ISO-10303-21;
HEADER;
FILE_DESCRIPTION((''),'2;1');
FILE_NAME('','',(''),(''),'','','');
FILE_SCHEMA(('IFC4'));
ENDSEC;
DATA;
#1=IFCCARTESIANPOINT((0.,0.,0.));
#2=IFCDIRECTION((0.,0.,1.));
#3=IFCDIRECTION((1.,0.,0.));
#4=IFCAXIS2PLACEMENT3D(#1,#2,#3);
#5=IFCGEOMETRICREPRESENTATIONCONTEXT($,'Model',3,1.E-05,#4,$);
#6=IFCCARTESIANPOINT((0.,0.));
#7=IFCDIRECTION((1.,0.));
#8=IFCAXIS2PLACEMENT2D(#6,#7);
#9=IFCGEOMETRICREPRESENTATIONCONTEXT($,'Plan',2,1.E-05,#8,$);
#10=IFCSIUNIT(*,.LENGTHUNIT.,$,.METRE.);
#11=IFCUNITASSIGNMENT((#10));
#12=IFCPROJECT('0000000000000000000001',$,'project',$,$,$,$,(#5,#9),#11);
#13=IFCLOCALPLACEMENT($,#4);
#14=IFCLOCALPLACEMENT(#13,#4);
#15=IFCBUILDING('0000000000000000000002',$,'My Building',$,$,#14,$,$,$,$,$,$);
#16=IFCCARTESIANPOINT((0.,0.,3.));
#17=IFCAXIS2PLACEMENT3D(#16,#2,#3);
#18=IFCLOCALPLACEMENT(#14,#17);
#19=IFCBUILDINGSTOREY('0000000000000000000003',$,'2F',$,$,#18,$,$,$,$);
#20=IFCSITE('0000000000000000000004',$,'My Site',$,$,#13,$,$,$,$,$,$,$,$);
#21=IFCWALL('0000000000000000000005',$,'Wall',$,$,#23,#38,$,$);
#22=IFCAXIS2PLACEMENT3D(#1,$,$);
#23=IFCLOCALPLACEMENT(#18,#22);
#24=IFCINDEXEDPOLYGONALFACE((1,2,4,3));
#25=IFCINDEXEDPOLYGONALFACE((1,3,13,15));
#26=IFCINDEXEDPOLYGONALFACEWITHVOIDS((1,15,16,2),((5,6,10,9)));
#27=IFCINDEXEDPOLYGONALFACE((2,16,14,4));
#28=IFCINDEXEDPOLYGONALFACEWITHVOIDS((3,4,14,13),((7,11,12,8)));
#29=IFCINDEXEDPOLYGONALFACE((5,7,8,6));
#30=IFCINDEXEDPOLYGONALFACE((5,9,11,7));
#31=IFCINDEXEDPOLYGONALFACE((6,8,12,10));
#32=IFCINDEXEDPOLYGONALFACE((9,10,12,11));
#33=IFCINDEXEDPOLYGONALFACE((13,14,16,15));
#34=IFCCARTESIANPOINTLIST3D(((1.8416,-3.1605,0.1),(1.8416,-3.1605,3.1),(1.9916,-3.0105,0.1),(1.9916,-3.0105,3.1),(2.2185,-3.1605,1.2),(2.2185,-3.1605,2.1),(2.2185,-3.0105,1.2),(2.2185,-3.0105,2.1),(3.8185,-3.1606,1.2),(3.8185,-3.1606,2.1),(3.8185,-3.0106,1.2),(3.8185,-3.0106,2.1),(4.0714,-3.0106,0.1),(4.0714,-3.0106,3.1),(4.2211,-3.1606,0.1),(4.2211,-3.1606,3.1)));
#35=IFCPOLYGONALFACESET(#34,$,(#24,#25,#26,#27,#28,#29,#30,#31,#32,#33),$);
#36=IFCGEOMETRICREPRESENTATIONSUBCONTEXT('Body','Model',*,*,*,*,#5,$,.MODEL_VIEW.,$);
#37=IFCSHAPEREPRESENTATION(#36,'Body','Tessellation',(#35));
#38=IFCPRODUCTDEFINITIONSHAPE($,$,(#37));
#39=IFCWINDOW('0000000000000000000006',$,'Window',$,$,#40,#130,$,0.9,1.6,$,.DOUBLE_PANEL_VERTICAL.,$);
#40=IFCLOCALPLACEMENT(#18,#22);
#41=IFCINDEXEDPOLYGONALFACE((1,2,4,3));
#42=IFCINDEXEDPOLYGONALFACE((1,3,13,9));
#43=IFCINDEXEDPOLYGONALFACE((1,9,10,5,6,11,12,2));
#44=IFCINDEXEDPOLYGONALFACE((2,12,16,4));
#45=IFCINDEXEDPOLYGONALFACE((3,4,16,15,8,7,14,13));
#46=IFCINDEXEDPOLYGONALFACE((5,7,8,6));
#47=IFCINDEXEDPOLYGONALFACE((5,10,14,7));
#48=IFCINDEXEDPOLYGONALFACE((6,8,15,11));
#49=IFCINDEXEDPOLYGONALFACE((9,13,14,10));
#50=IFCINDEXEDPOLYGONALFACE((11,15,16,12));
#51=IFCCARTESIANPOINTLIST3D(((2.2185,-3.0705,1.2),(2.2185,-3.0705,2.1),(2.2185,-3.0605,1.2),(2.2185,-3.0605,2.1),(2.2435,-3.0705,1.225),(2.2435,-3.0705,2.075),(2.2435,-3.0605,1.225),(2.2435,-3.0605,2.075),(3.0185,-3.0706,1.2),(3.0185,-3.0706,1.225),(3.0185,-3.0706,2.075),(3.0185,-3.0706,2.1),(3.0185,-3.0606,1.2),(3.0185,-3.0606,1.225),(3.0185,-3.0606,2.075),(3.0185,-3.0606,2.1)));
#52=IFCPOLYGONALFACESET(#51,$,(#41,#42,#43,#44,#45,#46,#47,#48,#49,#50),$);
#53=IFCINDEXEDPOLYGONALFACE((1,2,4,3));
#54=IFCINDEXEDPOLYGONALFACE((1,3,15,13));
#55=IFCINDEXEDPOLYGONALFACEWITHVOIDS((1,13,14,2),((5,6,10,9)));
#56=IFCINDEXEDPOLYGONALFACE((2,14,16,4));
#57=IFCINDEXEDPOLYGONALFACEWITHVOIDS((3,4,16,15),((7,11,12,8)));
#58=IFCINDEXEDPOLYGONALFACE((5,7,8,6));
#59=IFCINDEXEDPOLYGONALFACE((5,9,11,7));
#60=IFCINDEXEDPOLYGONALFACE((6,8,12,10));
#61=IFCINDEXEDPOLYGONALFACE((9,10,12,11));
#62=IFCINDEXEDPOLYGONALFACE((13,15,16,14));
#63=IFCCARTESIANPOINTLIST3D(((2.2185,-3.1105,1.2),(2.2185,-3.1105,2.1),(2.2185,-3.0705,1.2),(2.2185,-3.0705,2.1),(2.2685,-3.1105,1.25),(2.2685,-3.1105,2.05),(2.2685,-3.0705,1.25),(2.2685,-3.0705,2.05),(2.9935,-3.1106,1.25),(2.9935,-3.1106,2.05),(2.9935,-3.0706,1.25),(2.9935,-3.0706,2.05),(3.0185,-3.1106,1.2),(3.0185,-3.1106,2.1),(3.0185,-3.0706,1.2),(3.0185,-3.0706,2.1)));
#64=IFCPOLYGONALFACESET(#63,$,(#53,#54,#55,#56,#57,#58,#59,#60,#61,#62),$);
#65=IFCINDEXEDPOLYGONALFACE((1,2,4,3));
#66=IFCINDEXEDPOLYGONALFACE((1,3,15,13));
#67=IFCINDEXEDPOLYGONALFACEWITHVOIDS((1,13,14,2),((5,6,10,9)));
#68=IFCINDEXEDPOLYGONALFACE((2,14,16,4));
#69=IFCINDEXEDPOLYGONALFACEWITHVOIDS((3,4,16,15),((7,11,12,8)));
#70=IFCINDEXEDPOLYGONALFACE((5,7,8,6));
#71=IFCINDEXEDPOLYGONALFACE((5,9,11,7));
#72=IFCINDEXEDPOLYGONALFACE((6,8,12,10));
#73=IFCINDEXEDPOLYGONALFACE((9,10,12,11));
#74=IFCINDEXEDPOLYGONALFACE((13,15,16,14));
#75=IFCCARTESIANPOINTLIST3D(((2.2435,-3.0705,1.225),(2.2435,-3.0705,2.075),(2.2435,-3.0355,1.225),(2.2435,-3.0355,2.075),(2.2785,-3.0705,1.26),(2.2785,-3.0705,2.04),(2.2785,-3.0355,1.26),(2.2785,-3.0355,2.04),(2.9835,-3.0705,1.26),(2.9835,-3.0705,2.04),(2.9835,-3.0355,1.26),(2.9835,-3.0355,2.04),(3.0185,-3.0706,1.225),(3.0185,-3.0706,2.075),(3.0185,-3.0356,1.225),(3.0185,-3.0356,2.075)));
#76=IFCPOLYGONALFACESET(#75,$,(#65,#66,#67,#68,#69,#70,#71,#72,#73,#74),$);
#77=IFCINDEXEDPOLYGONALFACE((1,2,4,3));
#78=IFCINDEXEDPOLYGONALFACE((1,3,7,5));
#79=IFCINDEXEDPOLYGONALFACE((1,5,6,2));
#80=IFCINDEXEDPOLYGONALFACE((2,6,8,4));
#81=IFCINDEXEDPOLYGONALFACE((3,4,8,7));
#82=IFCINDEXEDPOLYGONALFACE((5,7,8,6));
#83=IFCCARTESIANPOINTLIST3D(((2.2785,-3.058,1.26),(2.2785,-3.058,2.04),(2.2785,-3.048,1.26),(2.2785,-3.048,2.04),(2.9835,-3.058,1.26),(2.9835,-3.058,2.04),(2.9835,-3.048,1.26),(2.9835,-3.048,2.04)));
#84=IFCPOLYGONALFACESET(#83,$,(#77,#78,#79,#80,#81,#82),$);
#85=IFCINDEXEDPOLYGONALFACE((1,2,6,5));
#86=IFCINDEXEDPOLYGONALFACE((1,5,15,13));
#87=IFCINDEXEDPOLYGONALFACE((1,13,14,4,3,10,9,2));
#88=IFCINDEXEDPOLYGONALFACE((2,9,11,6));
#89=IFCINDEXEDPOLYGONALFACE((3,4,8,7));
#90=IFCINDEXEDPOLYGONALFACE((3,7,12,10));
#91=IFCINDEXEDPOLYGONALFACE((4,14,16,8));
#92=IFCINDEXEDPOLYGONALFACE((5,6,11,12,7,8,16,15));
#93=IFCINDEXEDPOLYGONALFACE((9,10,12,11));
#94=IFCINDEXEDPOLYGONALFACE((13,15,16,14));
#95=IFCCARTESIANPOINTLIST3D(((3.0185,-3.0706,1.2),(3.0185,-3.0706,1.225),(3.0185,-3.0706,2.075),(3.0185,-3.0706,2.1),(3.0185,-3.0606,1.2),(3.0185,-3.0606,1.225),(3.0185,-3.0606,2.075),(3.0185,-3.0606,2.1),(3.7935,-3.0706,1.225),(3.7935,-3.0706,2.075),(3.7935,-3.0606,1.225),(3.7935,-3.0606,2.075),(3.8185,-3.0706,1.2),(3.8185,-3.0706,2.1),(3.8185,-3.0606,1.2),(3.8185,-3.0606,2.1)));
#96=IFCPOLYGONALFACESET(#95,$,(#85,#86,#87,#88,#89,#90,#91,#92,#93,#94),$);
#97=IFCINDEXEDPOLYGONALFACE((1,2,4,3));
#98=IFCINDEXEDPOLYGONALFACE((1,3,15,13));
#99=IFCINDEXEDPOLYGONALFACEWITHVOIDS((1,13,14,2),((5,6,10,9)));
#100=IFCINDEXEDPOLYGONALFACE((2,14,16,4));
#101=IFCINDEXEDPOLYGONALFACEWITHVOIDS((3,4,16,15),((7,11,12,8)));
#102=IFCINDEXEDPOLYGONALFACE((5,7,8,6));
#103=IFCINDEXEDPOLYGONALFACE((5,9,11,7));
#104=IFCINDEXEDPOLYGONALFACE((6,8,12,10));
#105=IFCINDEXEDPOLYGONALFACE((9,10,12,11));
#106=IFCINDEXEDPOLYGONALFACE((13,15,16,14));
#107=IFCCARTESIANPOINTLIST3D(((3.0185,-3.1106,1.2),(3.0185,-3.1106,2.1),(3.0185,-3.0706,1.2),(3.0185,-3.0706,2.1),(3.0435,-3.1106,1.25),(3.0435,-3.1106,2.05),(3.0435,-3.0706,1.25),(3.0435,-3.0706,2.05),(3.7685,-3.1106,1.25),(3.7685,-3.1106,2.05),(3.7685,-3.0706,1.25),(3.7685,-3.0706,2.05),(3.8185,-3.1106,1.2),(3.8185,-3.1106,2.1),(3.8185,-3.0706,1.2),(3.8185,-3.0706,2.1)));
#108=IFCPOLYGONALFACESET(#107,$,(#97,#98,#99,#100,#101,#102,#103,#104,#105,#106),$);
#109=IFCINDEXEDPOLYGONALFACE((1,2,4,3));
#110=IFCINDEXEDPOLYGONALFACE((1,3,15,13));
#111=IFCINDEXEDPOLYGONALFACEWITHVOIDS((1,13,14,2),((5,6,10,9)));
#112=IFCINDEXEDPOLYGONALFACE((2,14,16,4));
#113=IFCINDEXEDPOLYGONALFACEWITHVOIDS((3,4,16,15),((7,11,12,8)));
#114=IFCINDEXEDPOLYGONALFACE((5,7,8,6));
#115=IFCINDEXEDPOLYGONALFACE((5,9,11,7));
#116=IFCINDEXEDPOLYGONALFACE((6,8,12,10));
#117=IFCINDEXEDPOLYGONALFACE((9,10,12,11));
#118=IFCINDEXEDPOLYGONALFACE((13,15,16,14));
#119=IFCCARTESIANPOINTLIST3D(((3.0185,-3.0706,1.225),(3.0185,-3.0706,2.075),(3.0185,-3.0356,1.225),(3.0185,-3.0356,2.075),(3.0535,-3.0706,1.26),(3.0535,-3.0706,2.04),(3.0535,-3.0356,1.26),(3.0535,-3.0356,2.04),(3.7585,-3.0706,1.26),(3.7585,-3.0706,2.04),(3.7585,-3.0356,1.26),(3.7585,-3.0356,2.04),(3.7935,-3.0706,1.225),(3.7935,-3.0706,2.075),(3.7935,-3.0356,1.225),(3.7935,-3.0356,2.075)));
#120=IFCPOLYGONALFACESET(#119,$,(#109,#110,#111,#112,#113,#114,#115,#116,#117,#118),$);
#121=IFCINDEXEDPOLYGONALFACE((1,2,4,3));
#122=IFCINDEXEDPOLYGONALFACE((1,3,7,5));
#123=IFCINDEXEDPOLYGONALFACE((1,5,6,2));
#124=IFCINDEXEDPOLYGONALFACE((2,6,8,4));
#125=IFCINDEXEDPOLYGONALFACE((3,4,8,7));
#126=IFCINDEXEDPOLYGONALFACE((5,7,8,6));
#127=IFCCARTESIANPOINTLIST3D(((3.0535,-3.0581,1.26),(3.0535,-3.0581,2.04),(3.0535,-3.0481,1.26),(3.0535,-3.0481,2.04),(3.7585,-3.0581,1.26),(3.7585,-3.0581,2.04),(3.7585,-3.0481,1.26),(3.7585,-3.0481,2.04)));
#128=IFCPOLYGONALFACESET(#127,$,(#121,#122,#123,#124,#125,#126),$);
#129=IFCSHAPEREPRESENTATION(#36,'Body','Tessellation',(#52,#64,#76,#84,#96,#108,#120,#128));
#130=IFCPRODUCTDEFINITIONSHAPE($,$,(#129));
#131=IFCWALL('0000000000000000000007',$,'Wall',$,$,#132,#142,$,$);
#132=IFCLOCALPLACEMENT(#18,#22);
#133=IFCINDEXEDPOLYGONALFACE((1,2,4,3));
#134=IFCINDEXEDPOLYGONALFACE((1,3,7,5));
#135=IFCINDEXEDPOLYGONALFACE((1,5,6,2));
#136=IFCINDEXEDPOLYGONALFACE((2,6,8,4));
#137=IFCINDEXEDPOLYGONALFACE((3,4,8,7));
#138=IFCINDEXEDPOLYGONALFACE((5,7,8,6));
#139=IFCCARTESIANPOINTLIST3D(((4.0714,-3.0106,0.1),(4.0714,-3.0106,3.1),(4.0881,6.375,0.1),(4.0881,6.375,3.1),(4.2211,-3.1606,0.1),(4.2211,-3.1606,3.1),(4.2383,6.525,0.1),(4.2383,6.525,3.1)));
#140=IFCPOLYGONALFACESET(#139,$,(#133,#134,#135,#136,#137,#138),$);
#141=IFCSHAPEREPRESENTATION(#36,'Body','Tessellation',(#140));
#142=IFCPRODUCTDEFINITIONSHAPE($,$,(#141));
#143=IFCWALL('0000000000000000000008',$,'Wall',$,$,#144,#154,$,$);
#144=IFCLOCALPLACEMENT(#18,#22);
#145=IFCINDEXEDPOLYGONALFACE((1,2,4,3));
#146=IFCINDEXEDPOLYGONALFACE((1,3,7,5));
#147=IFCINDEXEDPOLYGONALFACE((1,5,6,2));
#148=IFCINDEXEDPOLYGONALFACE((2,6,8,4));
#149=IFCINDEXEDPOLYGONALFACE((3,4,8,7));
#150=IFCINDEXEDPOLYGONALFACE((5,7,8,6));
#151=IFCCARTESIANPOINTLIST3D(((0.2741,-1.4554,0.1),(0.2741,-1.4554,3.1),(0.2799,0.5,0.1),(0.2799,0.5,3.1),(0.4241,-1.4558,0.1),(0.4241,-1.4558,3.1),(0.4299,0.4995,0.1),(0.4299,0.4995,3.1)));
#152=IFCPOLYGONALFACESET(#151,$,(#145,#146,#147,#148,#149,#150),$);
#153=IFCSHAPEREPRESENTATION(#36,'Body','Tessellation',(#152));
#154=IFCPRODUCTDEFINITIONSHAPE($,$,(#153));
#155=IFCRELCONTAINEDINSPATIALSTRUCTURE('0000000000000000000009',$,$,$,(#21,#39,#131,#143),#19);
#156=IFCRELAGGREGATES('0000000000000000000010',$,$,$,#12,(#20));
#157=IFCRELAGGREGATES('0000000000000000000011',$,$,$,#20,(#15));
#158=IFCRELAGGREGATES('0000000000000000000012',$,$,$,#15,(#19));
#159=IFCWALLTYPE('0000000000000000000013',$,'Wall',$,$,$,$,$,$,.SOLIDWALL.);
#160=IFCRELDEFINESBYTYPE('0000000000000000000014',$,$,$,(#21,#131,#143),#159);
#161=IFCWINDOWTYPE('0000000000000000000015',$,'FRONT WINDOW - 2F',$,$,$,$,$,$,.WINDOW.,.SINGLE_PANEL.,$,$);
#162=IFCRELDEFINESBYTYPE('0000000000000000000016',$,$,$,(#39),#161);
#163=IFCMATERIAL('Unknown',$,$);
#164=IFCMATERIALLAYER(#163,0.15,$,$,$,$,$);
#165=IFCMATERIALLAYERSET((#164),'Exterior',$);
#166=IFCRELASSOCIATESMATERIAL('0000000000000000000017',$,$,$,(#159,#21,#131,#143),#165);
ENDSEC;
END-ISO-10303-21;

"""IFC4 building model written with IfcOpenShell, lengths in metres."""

from ifc_helpers import new_model, entity, si_unit, frame, origin_with_axes, origin_2d_with_axis, place, context, subcontext, project, spatial, line, indexed_curve, outline, extrude, shape, source, transform, mapped, material, layer, layer_set, layer_usage, type_object, type_shapes, element, fill, save


model = new_model("IFC4")

# Units and contexts
model_context = context("Model", 3, precision=1e-05, world=origin_with_axes())
plan_context = context("Plan", 2, precision=1e-05, world=origin_2d_with_axis())
body_context_1 = subcontext(model_context, "Body", "Model", "MODEL_VIEW")
body_context_2 = subcontext(plan_context, "Body", "Plan", "PLAN_VIEW")
ifc_project = project(units=[si_unit("LENGTHUNIT", "METRE")], contexts=[model_context, plan_context])

# Site, building, storey
site_placement = place(None, origin_with_axes())
site = spatial("IfcSite", under=ifc_project, at=site_placement, Name="My Site")
building_placement = place(site_placement, origin_with_axes())
building = spatial("IfcBuilding", under=site, at=building_placement, Name="My Building")
storey_placement = place(building_placement, frame((0.0, 0.0, 3.0), z_axis=(0.0, 0.0, 1.0), x_axis=(1.0, 0.0, 0.0)))
storey = spatial("IfcBuildingStorey", under=building, at=storey_placement, Name="2F")

# Shared definitions
ifc_material = material(Name="Unknown")

# Shared definitions
ifc_layer_1 = layer(ifc_material, 0.15)
ifc_layer_set_1 = layer_set([ifc_layer_1], Name="Exterior")
wall_type_1 = type_object("IfcWallType", Name="Wall", PredefinedType="SOLIDWALL", material=ifc_layer_set_1)

# Wall, opening, window
ifc_layer_usage_1 = layer_usage(ifc_layer_set_1, "AXIS2", "POSITIVE", 0.0)
wall_1_placement = place(storey_placement, frame((1.8416, -3.1605, 0.1), z_axis=(0.0, 0.0, 1.0), x_axis=(1.0, -0.000063, 0.0)))
wall_1 = element("IfcWall", 1, at=wall_1_placement, inside=storey, type_object=wall_type_1, material=ifc_layer_usage_1, Name="Wall", context=body_context_1, shape_type="SweptSolid", body=[
    extrude(outline(indexed_curve([(0.0, 0.0), (0.15, 0.15), (2.2297, 0.15), (2.3795, 0.0)], segments=[line(1, 2, 3, 4, 1)])), origin_with_axes(), (0.0, 0.0, 1.0), 3.0),
])
shared_shape_1 = source(origin_with_axes(), body_context_1, "Body", "SweptSolid", [
    extrude(outline(indexed_curve([(0.0, 0.0), (1.6, 0.0), (1.6, 0.9), (0.0, 0.9)], segments=[line(1, 2, 3, 4, 1)])), frame((0.0, -0.6, 0.0), z_axis=(0.0, -1.0, 0.0), x_axis=(1.0, 0.0, 0.0)), (0.0, 0.0, -1.0), 1.2),
])
opening_1_placement = place(wall_1_placement, frame((0.3769, 0.0, 1.1), z_axis=(0.0, 0.0, 1.0), x_axis=(1.0, 0.0, 0.0)))
opening_1 = element("IfcOpeningElement", 2, at=opening_1_placement, cuts=wall_1, PredefinedType="OPENING", context=body_context_1, shape_type="MappedRepresentation", body=[
    mapped(shared_shape_1, transform((0.0, 0.0, 0.0), x_axis=(1.0, 0.0, 0.0), y_axis=(0.0, 1.0, 0.0), z_axis=(0.0, 0.0, 1.0), scale=1.0)),
])
window_type_1 = type_object("IfcWindowType", Name="FRONT WINDOW - 2F", PartitioningType="SINGLE_PANEL", PredefinedType="WINDOW")
shared_shape_2 = source(origin_with_axes(), body_context_1, "Body", "SweptSolid", [
    extrude(outline(indexed_curve([(0.8, 0.0), (0.0, 0.0), (0.0, 0.9), (0.8, 0.9), (0.8, 0.875), (0.025, 0.875), (0.025, 0.025), (0.8, 0.025)], segments=[line(1, 2, 3, 4, 5, 6, 7, 8, 1)])), frame((0.0, 0.09, 0.0), z_axis=(0.0, -1.0, 0.0), x_axis=(1.0, 0.0, 0.0)), (0.0, 0.0, -1.0), 0.01),
    extrude(outline(indexed_curve([(0.0, 0.0), (0.8, 0.0), (0.8, 0.9), (0.0, 0.9)], segments=[line(1, 2, 3, 4, 1)]), holes=[indexed_curve([(0.05, 0.05), (0.775, 0.05), (0.775, 0.85), (0.05, 0.85)], segments=[line(1, 2, 3, 4, 1)])]), frame((0.0, 0.05, 0.0), z_axis=(0.0, -1.0, 0.0), x_axis=(1.0, 0.0, 0.0)), (0.0, 0.0, -1.0), 0.04),
    extrude(outline(indexed_curve([(0.0, 0.0), (0.775, 0.0), (0.775, 0.85), (0.0, 0.85)], segments=[line(1, 2, 3, 4, 1)]), holes=[indexed_curve([(0.035, 0.035), (0.74, 0.035), (0.74, 0.815), (0.035, 0.815)], segments=[line(1, 2, 3, 4, 1)])]), frame((0.025, 0.09, 0.025), z_axis=(0.0, -1.0, 0.0), x_axis=(1.0, 0.0, 0.0)), (0.0, 0.0, -1.0), 0.035),
    extrude(outline(indexed_curve([(0.035, 0.035), (0.74, 0.035), (0.74, 0.815), (0.035, 0.815)], segments=[line(1, 2, 3, 4, 1)])), frame((0.025, 0.1025, 0.025), z_axis=(0.0, -1.0, 0.0), x_axis=(1.0, 0.0, 0.0)), (0.0, 0.0, -1.0), 0.01),
    extrude(outline(indexed_curve([(0.0, 0.9), (0.8, 0.9), (0.8, 0.0), (0.0, 0.0), (0.0, 0.025), (0.775, 0.025), (0.775, 0.875), (0.0, 0.875)], segments=[line(1, 2, 3, 4, 5, 6, 7, 8, 1)])), frame((0.8, 0.09, 0.0), z_axis=(0.0, -1.0, 0.0), x_axis=(1.0, 0.0, 0.0)), (0.0, 0.0, -1.0), 0.01),
    extrude(outline(indexed_curve([(0.0, 0.0), (0.8, 0.0), (0.8, 0.9), (0.0, 0.9)], segments=[line(1, 2, 3, 4, 1)]), holes=[indexed_curve([(0.025, 0.05), (0.75, 0.05), (0.75, 0.85), (0.025, 0.85)], segments=[line(1, 2, 3, 4, 1)])]), frame((0.8, 0.05, 0.0), z_axis=(0.0, -1.0, 0.0), x_axis=(1.0, 0.0, 0.0)), (0.0, 0.0, -1.0), 0.04),
    extrude(outline(indexed_curve([(0.0, 0.0), (0.775, 0.0), (0.775, 0.85), (0.0, 0.85)], segments=[line(1, 2, 3, 4, 1)]), holes=[indexed_curve([(0.035, 0.035), (0.74, 0.035), (0.74, 0.815), (0.035, 0.815)], segments=[line(1, 2, 3, 4, 1)])]), frame((0.8, 0.09, 0.025), z_axis=(0.0, -1.0, 0.0), x_axis=(1.0, 0.0, 0.0)), (0.0, 0.0, -1.0), 0.035),
    extrude(outline(indexed_curve([(0.035, 0.035), (0.74, 0.035), (0.74, 0.815), (0.035, 0.815)], segments=[line(1, 2, 3, 4, 1)])), frame((0.8, 0.1025, 0.025), z_axis=(0.0, -1.0, 0.0), x_axis=(1.0, 0.0, 0.0)), (0.0, 0.0, -1.0), 0.01),
])
shared_shape_3 = source(origin_with_axes(), body_context_2, "Body", "Curve2D", [
    entity("IfcIndexedPolyCurve", entity("IfcCartesianPointList2D", [[0.05, 0.05], [0.775, 0.05]])),
    entity("IfcIndexedPolyCurve", entity("IfcCartesianPointList2D", [[0.0, 0.1], [0.025, 0.1], [0.025, 0.09], [0.05, 0.09], [0.05, 0.05], [0.0, 0.05]]), [entity("IfcLineIndex", [1, 2, 3, 4, 5, 6, 1])]),
    entity("IfcIndexedPolyCurve", entity("IfcCartesianPointList2D", [[0.8, 0.1], [0.8, 0.1], [0.8, 0.09], [0.775, 0.09], [0.775, 0.05], [0.8, 0.05]])),
    entity("IfcIndexedPolyCurve", entity("IfcCartesianPointList2D", [[0.025, 0.09], [0.06, 0.09], [0.06, 0.125], [0.025, 0.125]]), [entity("IfcLineIndex", [1, 2, 3, 4, 1])]),
    entity("IfcIndexedPolyCurve", entity("IfcCartesianPointList2D", [[0.8, 0.09], [0.765, 0.09], [0.765, 0.125], [0.8, 0.125]]), [entity("IfcLineIndex", [1, 2, 3, 4, 1])]),
    entity("IfcIndexedPolyCurve", entity("IfcCartesianPointList2D", [[0.06, 0.09], [0.765, 0.09]])),
    entity("IfcIndexedPolyCurve", entity("IfcCartesianPointList2D", [[0.06, 0.125], [0.765, 0.125]])),
    entity("IfcIndexedPolyCurve", entity("IfcCartesianPointList2D", [[0.06, 0.1075], [0.765, 0.1075]])),
    entity("IfcIndexedPolyCurve", entity("IfcCartesianPointList2D", [[0.825, 0.05], [1.55, 0.05]])),
    entity("IfcIndexedPolyCurve", entity("IfcCartesianPointList2D", [[0.8, 0.1], [0.8, 0.1], [0.8, 0.09], [0.825, 0.09], [0.825, 0.05], [0.8, 0.05]])),
    entity("IfcIndexedPolyCurve", entity("IfcCartesianPointList2D", [[1.6, 0.1], [1.575, 0.1], [1.575, 0.09], [1.55, 0.09], [1.55, 0.05], [1.6, 0.05]]), [entity("IfcLineIndex", [1, 2, 3, 4, 5, 6, 1])]),
    entity("IfcIndexedPolyCurve", entity("IfcCartesianPointList2D", [[0.8, 0.09], [0.835, 0.09], [0.835, 0.125], [0.8, 0.125]]), [entity("IfcLineIndex", [1, 2, 3, 4, 1])]),
    entity("IfcIndexedPolyCurve", entity("IfcCartesianPointList2D", [[1.575, 0.09], [1.54, 0.09], [1.54, 0.125], [1.575, 0.125]]), [entity("IfcLineIndex", [1, 2, 3, 4, 1])]),
    entity("IfcIndexedPolyCurve", entity("IfcCartesianPointList2D", [[0.835, 0.09], [1.54, 0.09]])),
    entity("IfcIndexedPolyCurve", entity("IfcCartesianPointList2D", [[0.835, 0.125], [1.54, 0.125]])),
    entity("IfcIndexedPolyCurve", entity("IfcCartesianPointList2D", [[0.835, 0.1075], [1.54, 0.1075]])),
])
type_shapes(window_type_1, [shared_shape_2, shared_shape_3])
window_1_placement = place(opening_1_placement, frame((0.0, 0.0, 0.0), z_axis=(0.0, 0.0, 1.0), x_axis=(1.0, 0.0, 0.0)))
window_1 = element("IfcWindow", 3, at=window_1_placement, inside=storey, type_object=window_type_1, Name="Window", OverallHeight=0.9, OverallWidth=1.6, PartitioningType="DOUBLE_PANEL_VERTICAL", shapes=[
    shape(body_context_1, "Body", "MappedRepresentation", [mapped(shared_shape_2, transform((0.0, 0.0, 0.0), x_axis=(1.0, 0.0, 0.0), y_axis=(0.0, 1.0, 0.0), z_axis=(0.0, 0.0, 1.0), scale=1.0))]),
    shape(body_context_2, "Body", "MappedRepresentation", [mapped(shared_shape_3, transform((0.0, 0.0, 0.0), x_axis=(1.0, 0.0, 0.0), y_axis=(0.0, 1.0, 0.0), z_axis=(0.0, 0.0, 1.0), scale=1.0))]),
])
fill(opening_1, window_1)

# Walls
ifc_layer_usage_2 = layer_usage(ifc_layer_set_1, "AXIS2", "POSITIVE", 0.0)
wall_2_placement = place(storey_placement, frame((4.2211, -3.1606, 0.1), z_axis=(0.0, 0.0, 1.0), x_axis=(0.001781, 0.999998, 0.0)))
element("IfcWall", 4, at=wall_2_placement, inside=storey, type_object=wall_type_1, material=ifc_layer_usage_2, Name="Wall", context=body_context_1, shape_type="SweptSolid", body=[
    extrude(outline(indexed_curve([(0.0, 0.0), (0.1497, 0.15), (9.5354, 0.15), (9.6856, 0.0)], segments=[line(1, 2, 3, 4, 1)])), origin_with_axes(), (0.0, 0.0, 1.0), 3.0),
])
ifc_layer_usage_3 = layer_usage(ifc_layer_set_1, "AXIS2", "POSITIVE", 0.0)
wall_3_placement = place(storey_placement, frame((0.2799, 0.5, 0.1), z_axis=(0.0, 0.0, 1.0), x_axis=(-0.00298, -0.999996, 0.0)))
element("IfcWall", 5, at=wall_3_placement, inside=storey, type_object=wall_type_1, material=ifc_layer_usage_3, Name="Wall", context=body_context_1, shape_type="SweptSolid", body=[
    extrude(outline(indexed_curve([(0.0, 0.0), (0.0, 0.15), (1.9554, 0.15), (1.9554, 0.0)], segments=[line(1, 2, 3, 4, 1)])), origin_with_axes(), (0.0, 0.0, 1.0), 3.0),
])

save(model, "model.ifc")
